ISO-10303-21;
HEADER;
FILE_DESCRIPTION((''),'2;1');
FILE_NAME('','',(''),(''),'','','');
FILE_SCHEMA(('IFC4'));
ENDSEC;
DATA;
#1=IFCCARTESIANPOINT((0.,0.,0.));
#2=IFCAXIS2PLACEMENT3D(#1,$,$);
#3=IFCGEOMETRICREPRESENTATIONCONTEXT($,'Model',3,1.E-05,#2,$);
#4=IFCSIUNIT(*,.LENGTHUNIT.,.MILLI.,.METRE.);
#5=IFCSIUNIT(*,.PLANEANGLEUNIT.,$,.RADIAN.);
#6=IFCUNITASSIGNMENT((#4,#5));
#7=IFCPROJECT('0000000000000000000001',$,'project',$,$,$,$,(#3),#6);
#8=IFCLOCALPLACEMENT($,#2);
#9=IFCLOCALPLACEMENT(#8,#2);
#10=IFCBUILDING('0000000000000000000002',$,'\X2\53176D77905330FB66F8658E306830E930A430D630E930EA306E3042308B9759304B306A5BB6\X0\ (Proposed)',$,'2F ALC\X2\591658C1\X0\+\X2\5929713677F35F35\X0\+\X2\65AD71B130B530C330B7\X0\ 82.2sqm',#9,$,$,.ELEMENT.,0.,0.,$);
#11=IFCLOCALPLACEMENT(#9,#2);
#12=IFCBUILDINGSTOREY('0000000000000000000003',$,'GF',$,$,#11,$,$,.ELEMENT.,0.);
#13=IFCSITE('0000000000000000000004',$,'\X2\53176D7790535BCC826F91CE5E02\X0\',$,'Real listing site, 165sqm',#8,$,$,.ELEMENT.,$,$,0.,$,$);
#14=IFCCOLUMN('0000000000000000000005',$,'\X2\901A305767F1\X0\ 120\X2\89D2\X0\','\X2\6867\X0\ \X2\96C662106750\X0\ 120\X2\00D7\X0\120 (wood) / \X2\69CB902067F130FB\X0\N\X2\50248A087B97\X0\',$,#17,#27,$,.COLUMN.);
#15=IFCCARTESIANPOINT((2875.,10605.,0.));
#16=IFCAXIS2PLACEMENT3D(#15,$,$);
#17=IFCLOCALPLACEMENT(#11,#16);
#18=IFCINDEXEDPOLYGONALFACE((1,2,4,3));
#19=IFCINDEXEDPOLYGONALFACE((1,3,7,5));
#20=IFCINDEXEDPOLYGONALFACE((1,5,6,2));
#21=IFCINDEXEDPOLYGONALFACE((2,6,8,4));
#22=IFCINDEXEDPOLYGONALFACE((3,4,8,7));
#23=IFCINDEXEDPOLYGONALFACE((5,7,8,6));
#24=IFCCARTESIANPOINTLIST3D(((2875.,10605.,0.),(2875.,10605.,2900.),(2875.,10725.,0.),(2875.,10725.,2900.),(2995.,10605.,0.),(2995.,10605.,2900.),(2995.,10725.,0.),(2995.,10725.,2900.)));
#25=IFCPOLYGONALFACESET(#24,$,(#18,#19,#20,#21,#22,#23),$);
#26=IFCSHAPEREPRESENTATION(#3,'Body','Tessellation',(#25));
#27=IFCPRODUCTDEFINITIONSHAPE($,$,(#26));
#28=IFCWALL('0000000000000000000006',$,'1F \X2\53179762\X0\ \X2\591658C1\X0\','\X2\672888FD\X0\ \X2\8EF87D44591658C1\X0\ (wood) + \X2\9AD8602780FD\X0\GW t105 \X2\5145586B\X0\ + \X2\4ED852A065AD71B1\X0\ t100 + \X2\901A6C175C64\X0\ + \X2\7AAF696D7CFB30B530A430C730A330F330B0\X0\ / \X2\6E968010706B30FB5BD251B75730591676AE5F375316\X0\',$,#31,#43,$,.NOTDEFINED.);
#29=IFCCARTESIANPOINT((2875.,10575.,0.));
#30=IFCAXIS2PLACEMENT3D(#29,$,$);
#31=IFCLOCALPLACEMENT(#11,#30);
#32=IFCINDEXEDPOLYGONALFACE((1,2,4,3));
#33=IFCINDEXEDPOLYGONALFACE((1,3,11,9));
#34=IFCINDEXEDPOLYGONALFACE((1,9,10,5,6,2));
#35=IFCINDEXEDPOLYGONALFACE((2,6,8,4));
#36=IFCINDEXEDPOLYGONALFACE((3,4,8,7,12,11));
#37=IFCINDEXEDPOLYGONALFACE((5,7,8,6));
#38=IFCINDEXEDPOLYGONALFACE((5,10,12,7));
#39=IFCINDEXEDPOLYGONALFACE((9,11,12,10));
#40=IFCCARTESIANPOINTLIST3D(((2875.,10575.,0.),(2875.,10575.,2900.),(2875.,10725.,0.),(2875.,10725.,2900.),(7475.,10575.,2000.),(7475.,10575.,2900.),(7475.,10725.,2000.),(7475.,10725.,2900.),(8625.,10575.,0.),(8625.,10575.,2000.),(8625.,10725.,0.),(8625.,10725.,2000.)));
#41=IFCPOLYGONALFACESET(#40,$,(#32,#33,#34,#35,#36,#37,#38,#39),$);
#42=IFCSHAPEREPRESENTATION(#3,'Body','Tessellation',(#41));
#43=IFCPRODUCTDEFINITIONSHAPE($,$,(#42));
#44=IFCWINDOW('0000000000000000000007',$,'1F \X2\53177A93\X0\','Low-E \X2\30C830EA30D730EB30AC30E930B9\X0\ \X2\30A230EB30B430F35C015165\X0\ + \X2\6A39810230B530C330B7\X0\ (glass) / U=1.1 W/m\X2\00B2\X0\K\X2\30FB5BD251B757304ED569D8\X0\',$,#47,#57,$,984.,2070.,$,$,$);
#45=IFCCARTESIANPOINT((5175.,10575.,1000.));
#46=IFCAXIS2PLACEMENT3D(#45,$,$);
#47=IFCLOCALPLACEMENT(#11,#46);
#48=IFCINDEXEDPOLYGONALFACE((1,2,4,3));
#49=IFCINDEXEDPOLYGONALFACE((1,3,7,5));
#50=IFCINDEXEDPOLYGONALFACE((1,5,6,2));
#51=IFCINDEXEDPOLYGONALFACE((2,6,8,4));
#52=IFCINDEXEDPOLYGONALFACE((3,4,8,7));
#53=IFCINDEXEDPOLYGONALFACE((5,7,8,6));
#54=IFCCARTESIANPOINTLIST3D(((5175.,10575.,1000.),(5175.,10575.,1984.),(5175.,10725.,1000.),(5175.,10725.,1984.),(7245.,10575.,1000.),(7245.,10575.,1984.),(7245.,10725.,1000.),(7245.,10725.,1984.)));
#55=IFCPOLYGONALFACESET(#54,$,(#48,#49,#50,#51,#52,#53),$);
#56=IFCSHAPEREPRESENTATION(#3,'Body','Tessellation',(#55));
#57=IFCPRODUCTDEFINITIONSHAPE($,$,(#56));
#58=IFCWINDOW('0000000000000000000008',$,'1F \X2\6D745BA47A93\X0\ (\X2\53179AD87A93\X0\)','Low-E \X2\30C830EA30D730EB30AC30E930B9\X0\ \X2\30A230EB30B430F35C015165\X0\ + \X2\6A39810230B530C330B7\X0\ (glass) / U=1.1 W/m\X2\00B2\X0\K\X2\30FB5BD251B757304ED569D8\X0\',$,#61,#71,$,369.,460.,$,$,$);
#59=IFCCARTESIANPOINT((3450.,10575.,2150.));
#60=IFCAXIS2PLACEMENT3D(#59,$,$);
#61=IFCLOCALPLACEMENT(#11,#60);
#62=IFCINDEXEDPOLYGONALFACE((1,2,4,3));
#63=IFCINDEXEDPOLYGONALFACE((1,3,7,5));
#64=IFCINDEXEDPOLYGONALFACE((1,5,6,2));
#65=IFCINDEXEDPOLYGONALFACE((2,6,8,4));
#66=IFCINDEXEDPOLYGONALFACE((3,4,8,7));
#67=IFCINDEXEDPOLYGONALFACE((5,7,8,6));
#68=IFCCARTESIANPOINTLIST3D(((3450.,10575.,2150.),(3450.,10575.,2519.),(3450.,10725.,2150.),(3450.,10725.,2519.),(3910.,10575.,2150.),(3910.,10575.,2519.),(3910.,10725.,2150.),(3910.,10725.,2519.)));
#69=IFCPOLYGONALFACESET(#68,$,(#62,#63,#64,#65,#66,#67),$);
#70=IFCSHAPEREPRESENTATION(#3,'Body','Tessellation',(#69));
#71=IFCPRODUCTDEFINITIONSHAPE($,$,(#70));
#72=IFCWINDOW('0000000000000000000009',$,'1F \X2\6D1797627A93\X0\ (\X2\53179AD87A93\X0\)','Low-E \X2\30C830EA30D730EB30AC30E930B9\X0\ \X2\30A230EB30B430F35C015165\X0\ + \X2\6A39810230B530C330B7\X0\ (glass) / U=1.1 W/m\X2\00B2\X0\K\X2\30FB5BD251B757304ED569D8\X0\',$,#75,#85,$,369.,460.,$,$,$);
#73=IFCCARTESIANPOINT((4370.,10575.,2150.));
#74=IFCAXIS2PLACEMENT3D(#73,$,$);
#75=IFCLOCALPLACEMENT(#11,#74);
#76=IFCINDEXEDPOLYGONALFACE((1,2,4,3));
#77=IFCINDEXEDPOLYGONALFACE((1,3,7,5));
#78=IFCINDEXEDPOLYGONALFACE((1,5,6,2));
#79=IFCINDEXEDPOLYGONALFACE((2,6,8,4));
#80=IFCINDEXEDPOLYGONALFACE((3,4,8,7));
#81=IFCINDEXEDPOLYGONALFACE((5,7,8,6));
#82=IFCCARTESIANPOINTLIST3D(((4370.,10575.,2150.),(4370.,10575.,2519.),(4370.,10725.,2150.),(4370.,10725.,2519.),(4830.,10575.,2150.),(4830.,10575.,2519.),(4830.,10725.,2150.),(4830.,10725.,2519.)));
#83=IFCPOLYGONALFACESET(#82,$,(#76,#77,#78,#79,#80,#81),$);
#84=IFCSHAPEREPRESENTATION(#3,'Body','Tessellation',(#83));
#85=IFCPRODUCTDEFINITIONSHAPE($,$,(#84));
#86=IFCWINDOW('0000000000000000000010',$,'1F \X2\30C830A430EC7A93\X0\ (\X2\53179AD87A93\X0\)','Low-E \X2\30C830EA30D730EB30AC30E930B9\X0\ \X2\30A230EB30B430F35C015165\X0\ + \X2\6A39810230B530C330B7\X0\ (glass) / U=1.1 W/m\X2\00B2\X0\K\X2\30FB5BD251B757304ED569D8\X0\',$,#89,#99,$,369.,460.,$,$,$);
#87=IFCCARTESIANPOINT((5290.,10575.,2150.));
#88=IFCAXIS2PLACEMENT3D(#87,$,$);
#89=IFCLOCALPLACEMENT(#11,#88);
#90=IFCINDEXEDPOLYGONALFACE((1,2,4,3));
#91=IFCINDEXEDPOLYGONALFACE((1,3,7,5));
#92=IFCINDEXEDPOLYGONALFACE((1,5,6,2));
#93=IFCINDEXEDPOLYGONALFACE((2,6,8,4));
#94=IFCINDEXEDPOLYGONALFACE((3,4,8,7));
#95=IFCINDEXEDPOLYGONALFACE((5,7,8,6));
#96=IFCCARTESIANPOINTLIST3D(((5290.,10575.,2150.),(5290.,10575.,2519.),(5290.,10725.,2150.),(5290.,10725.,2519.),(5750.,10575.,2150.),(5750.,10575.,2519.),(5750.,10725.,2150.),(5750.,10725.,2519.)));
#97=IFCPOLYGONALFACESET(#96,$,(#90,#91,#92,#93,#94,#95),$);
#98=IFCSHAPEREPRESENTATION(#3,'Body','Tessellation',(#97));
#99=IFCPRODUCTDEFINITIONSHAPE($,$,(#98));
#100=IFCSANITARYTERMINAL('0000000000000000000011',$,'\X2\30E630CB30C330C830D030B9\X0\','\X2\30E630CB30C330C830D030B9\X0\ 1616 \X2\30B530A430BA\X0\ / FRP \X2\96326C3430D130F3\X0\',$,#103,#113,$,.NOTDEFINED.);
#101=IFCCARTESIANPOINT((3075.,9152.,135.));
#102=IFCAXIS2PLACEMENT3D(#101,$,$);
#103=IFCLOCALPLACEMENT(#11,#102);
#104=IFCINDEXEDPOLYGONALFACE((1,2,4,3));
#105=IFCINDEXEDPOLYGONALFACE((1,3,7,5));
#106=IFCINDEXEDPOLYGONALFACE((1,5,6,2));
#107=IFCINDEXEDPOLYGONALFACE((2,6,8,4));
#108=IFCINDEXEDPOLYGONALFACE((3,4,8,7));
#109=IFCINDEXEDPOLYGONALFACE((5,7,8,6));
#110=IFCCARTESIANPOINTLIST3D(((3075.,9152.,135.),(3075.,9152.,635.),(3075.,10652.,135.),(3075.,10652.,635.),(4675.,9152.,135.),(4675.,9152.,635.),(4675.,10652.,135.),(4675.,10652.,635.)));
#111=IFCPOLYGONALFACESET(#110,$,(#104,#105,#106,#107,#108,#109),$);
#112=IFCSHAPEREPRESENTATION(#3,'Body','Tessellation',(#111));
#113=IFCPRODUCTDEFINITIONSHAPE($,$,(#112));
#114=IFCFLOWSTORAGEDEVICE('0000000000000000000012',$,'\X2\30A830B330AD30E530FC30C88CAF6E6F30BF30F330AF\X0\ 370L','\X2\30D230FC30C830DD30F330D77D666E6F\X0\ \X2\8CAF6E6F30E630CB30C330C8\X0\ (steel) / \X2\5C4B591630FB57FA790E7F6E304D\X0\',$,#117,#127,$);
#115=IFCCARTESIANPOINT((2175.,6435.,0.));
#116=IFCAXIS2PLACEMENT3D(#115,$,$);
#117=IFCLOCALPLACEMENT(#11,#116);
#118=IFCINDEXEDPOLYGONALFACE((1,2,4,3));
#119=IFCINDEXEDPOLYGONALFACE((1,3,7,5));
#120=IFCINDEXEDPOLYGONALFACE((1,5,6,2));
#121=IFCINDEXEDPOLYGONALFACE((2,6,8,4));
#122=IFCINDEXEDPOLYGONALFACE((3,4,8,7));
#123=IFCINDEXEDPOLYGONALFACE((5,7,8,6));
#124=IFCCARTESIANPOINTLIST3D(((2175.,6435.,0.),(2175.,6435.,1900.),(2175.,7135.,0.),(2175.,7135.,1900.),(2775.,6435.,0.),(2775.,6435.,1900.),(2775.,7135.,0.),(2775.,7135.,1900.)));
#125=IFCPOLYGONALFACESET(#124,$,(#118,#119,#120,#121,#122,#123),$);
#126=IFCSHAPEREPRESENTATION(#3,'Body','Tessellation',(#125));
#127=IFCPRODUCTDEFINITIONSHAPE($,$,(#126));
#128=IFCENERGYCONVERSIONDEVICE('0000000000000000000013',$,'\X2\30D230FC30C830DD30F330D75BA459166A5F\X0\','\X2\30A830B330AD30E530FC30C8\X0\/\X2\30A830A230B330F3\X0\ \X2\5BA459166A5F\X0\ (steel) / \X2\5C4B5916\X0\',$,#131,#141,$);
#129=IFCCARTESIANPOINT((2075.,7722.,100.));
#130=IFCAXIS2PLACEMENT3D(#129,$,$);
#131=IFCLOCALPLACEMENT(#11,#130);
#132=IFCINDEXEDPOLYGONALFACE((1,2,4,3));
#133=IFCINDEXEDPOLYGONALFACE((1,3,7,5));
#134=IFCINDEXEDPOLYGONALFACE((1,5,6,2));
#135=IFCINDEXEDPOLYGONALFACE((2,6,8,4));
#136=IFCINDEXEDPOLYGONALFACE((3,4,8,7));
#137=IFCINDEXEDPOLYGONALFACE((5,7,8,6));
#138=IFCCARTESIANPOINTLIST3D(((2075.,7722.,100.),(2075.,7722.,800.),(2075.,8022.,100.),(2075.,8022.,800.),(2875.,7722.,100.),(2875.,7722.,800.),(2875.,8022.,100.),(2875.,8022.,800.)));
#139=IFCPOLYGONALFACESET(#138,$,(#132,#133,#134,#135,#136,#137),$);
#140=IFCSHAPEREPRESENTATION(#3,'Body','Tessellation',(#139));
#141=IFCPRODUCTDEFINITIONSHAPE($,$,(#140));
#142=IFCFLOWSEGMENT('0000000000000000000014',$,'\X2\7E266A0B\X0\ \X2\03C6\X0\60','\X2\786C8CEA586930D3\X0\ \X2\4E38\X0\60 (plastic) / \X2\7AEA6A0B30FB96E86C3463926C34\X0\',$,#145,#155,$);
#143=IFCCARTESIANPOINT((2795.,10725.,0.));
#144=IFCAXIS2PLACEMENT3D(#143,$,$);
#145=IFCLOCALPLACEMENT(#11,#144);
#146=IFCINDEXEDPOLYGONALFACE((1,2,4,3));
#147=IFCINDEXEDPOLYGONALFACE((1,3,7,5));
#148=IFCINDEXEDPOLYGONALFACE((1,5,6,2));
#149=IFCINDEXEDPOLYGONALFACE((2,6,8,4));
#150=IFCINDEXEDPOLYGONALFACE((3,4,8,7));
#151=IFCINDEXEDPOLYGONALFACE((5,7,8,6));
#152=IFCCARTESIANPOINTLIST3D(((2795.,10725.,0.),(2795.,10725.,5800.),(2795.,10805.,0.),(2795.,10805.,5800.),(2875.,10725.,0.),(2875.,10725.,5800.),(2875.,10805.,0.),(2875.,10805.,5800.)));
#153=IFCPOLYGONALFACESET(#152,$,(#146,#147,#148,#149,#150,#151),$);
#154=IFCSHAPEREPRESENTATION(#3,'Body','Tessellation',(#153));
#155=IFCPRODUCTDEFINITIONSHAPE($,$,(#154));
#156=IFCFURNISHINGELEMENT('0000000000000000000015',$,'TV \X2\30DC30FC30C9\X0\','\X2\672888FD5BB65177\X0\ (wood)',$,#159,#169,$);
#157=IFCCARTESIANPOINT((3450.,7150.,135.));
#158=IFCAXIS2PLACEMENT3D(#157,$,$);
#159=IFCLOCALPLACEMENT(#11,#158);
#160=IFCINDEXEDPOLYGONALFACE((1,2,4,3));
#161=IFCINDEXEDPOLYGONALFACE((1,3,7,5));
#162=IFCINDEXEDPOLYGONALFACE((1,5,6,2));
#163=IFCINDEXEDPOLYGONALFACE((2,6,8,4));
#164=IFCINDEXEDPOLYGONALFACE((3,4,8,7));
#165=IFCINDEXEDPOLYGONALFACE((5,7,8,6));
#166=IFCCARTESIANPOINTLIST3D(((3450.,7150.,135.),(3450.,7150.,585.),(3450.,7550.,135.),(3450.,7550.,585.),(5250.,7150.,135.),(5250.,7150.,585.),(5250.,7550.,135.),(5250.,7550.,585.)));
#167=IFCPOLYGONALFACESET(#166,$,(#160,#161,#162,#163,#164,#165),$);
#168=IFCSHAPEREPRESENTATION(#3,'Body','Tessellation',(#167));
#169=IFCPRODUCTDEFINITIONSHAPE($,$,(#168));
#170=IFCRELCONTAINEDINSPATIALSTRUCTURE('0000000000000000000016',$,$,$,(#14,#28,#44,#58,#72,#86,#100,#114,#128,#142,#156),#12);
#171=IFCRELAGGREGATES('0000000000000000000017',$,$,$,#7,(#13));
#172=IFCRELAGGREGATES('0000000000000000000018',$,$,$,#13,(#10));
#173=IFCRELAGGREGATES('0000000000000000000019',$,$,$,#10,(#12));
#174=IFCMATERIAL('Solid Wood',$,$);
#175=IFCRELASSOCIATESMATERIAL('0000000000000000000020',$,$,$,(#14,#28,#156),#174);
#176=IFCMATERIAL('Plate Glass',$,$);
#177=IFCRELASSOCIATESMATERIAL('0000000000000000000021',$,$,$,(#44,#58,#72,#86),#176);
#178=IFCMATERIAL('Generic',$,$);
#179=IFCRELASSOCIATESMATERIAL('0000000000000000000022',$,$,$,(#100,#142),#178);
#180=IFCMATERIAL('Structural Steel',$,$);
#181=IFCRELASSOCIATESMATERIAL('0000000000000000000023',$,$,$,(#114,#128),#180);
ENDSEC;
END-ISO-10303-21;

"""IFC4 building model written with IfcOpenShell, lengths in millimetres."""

from ifc_helpers import new_model, si_unit, frame, frame_2d, origin, place, context, project, spatial, rectangle, extrude, material, element, fill, save


model = new_model("IFC4")

# Units and contexts
model_context = context("Model", 3, precision=1e-05, world=origin())
ifc_project = project(units=[si_unit("LENGTHUNIT", "METRE", prefix="MILLI"), si_unit("PLANEANGLEUNIT", "RADIAN")], contexts=[model_context])

# Site, building, storey
site_placement = place(None, origin())
site = spatial("IfcSite", under=ifc_project, at=site_placement, Name="北海道富良野市", ObjectType="Real listing site, 165sqm", CompositionType="ELEMENT", RefElevation=0.0)
building_placement = place(site_placement, origin())
building = spatial("IfcBuilding", under=site, at=building_placement, Name="北海道・書斎とライブラリのある静かな家 (Proposed)", ObjectType="2F ALC外壁+天然石張+断熱サッシ 82.2sqm", CompositionType="ELEMENT", ElevationOfRefHeight=0.0, ElevationOfTerrain=0.0)
storey_placement = place(building_placement, origin())
storey = spatial("IfcBuildingStorey", under=building, at=storey_placement, Name="GF", CompositionType="ELEMENT", Elevation=0.0)

# Column
ifc_material_1 = material(Name="Solid Wood")
column_1_placement = place(storey_placement, frame((2875.0, 10605.0, 0.0)))
element("IfcColumn", 1, at=column_1_placement, inside=storey, material=ifc_material_1, Name="通し柱 120角", Description="桧 集成材 120×120 (wood) / 構造柱・N値計算", PredefinedType="COLUMN", context=model_context, shape_type="SweptSolid", body=[
    extrude(rectangle(XDim=120.0, YDim=120.0, at=frame_2d((60.0, 60.0))), frame((2875.0, 10605.0, 0.0)), (0.0, 0.0, 1.0), 2900.0),
])

# Wall, openings, windows
wall_1_placement = place(storey_placement, frame((2875.0, 10575.0, 0.0)))
wall_1 = element("IfcWall", 2, at=wall_1_placement, inside=storey, material=ifc_material_1, Name="1F 北面 外壁", Description="木製 軸組外壁 (wood) + 高性能GW t105 充填 + 付加断熱 t100 + 通気層 + 窯業系サイディング / 準耐火・寒冷地外皮強化", PredefinedType="NOTDEFINED", context=model_context, shape_type="SweptSolid", body=[
    extrude(rectangle(XDim=5750.0, YDim=150.0, at=frame_2d((2875.0, 75.0))), frame((2875.0, 10575.0, 0.0)), (0.0, 0.0, 1.0), 2900.0),
])
opening_1_placement = place(storey_placement, frame((5175.0, 10575.0, 1000.0)))
opening_1 = element("IfcOpeningElement", 3, at=opening_1_placement, cuts=wall_1, PredefinedType="NOTDEFINED", context=model_context, shape_type="SweptSolid", body=[
    extrude(rectangle(XDim=2070.0, YDim=150.0, at=frame_2d((1035.0, 75.0))), frame((5175.0, 10575.0, 1000.0)), (0.0, 0.0, 1.0), 984.0),
])
opening_2_placement = place(storey_placement, frame((3450.0, 10575.0, 2150.0)))
opening_2 = element("IfcOpeningElement", 4, at=opening_2_placement, cuts=wall_1, PredefinedType="NOTDEFINED", context=model_context, shape_type="SweptSolid", body=[
    extrude(rectangle(XDim=460.0, YDim=150.0, at=frame_2d((230.0, 75.0))), frame((3450.0, 10575.0, 2150.0)), (0.0, 0.0, 1.0), 369.0),
])
opening_3_placement = place(storey_placement, frame((4370.0, 10575.0, 2150.0)))
opening_3 = element("IfcOpeningElement", 5, at=opening_3_placement, cuts=wall_1, PredefinedType="NOTDEFINED", context=model_context, shape_type="SweptSolid", body=[
    extrude(rectangle(XDim=460.0, YDim=150.0, at=frame_2d((230.0, 75.0))), frame((4370.0, 10575.0, 2150.0)), (0.0, 0.0, 1.0), 369.0),
])
opening_4_placement = place(storey_placement, frame((5290.0, 10575.0, 2150.0)))
opening_4 = element("IfcOpeningElement", 6, at=opening_4_placement, cuts=wall_1, PredefinedType="NOTDEFINED", context=model_context, shape_type="SweptSolid", body=[
    extrude(rectangle(XDim=460.0, YDim=150.0, at=frame_2d((230.0, 75.0))), frame((5290.0, 10575.0, 2150.0)), (0.0, 0.0, 1.0), 369.0),
])
ifc_material_2 = material(Name="Plate Glass")
window_1_placement = place(storey_placement, frame((5175.0, 10575.0, 1000.0)))
window_1 = element("IfcWindow", 7, at=window_1_placement, inside=storey, material=ifc_material_2, Name="1F 北窓", Description="Low-E トリプルガラス アルゴン封入 + 樹脂サッシ (glass) / U=1.1 W/m²K・寒冷地仕様", OverallHeight=984.0, OverallWidth=2070.0, context=model_context, shape_type="SweptSolid", body=[
    extrude(rectangle(XDim=2070.0, YDim=150.0, at=frame_2d((1035.0, 75.0))), frame((5175.0, 10575.0, 1000.0)), (0.0, 0.0, 1.0), 984.0),
])
fill(opening_1, window_1)
window_2_placement = place(storey_placement, frame((3450.0, 10575.0, 2150.0)))
window_2 = element("IfcWindow", 8, at=window_2_placement, inside=storey, material=ifc_material_2, Name="1F 浴室窓 (北高窓)", Description="Low-E トリプルガラス アルゴン封入 + 樹脂サッシ (glass) / U=1.1 W/m²K・寒冷地仕様", OverallHeight=369.0, OverallWidth=460.0, context=model_context, shape_type="SweptSolid", body=[
    extrude(rectangle(XDim=460.0, YDim=150.0, at=frame_2d((230.0, 75.0))), frame((3450.0, 10575.0, 2150.0)), (0.0, 0.0, 1.0), 369.0),
])
fill(opening_2, window_2)
window_3_placement = place(storey_placement, frame((4370.0, 10575.0, 2150.0)))
window_3 = element("IfcWindow", 9, at=window_3_placement, inside=storey, material=ifc_material_2, Name="1F 洗面窓 (北高窓)", Description="Low-E トリプルガラス アルゴン封入 + 樹脂サッシ (glass) / U=1.1 W/m²K・寒冷地仕様", OverallHeight=369.0, OverallWidth=460.0, context=model_context, shape_type="SweptSolid", body=[
    extrude(rectangle(XDim=460.0, YDim=150.0, at=frame_2d((230.0, 75.0))), frame((4370.0, 10575.0, 2150.0)), (0.0, 0.0, 1.0), 369.0),
])
fill(opening_3, window_3)
window_4_placement = place(storey_placement, frame((5290.0, 10575.0, 2150.0)))
window_4 = element("IfcWindow", 10, at=window_4_placement, inside=storey, material=ifc_material_2, Name="1F トイレ窓 (北高窓)", Description="Low-E トリプルガラス アルゴン封入 + 樹脂サッシ (glass) / U=1.1 W/m²K・寒冷地仕様", OverallHeight=369.0, OverallWidth=460.0, context=model_context, shape_type="SweptSolid", body=[
    extrude(rectangle(XDim=460.0, YDim=150.0, at=frame_2d((230.0, 75.0))), frame((5290.0, 10575.0, 2150.0)), (0.0, 0.0, 1.0), 369.0),
])
fill(opening_4, window_4)

# Sanitary terminal
ifc_material_3 = material(Name="Generic")
sanitary_terminal_placement = place(storey_placement, frame((3075.0, 9152.0, 135.0)))
element("IfcSanitaryTerminal", 11, at=sanitary_terminal_placement, inside=storey, material=ifc_material_3, Name="ユニットバス", Description="ユニットバス 1616 サイズ / FRP 防水パン", PredefinedType="NOTDEFINED", context=model_context, shape_type="SweptSolid", body=[
    extrude(rectangle(XDim=1600.0, YDim=1500.0, at=frame_2d((800.0, 750.0))), frame((3075.0, 9152.0, 135.0)), (0.0, 0.0, 1.0), 500.0),
])

# Flow storage device
ifc_material_4 = material(Name="Structural Steel")
flow_storage_device_placement = place(storey_placement, frame((2175.0, 6435.0, 0.0)))
element("IfcFlowStorageDevice", 12, at=flow_storage_device_placement, inside=storey, material=ifc_material_4, Name="エコキュート貯湯タンク 370L", Description="ヒートポンプ給湯 貯湯ユニット (steel) / 屋外・基礎置き", context=model_context, shape_type="SweptSolid", body=[
    extrude(rectangle(XDim=600.0, YDim=700.0, at=frame_2d((300.0, 350.0))), frame((2175.0, 6435.0, 0.0)), (0.0, 0.0, 1.0), 1900.0),
])

# Energy conversion device
energy_conversion_device_placement = place(storey_placement, frame((2075.0, 7722.0, 100.0)))
element("IfcEnergyConversionDevice", 13, at=energy_conversion_device_placement, inside=storey, material=ifc_material_4, Name="ヒートポンプ室外機", Description="エコキュート/エアコン 室外機 (steel) / 屋外", context=model_context, shape_type="SweptSolid", body=[
    extrude(rectangle(XDim=800.0, YDim=300.0, at=frame_2d((400.0, 150.0))), frame((2075.0, 7722.0, 100.0)), (0.0, 0.0, 1.0), 700.0),
])

# Flow segment
flow_segment_placement = place(storey_placement, frame((2795.0, 10725.0, 0.0)))
element("IfcFlowSegment", 14, at=flow_segment_placement, inside=storey, material=ifc_material_3, Name="縦樋 φ60", Description="硬質塩ビ 丸60 (plastic) / 竪樋・雨水排水", context=model_context, shape_type="SweptSolid", body=[
    extrude(rectangle(XDim=80.0, YDim=80.0, at=frame_2d((40.0, 40.0))), frame((2795.0, 10725.0, 0.0)), (0.0, 0.0, 1.0), 5800.0),
])

# Furnishing element
furnishing_placement = place(storey_placement, frame((3450.0, 7150.0, 135.0)))
element("IfcFurnishingElement", 15, at=furnishing_placement, inside=storey, material=ifc_material_1, Name="TV ボード", Description="木製家具 (wood)", context=model_context, shape_type="SweptSolid", body=[
    extrude(rectangle(XDim=1800.0, YDim=400.0, at=frame_2d((900.0, 200.0))), frame((3450.0, 7150.0, 135.0)), (0.0, 0.0, 1.0), 450.0),
])

save(model, "model.ifc")
